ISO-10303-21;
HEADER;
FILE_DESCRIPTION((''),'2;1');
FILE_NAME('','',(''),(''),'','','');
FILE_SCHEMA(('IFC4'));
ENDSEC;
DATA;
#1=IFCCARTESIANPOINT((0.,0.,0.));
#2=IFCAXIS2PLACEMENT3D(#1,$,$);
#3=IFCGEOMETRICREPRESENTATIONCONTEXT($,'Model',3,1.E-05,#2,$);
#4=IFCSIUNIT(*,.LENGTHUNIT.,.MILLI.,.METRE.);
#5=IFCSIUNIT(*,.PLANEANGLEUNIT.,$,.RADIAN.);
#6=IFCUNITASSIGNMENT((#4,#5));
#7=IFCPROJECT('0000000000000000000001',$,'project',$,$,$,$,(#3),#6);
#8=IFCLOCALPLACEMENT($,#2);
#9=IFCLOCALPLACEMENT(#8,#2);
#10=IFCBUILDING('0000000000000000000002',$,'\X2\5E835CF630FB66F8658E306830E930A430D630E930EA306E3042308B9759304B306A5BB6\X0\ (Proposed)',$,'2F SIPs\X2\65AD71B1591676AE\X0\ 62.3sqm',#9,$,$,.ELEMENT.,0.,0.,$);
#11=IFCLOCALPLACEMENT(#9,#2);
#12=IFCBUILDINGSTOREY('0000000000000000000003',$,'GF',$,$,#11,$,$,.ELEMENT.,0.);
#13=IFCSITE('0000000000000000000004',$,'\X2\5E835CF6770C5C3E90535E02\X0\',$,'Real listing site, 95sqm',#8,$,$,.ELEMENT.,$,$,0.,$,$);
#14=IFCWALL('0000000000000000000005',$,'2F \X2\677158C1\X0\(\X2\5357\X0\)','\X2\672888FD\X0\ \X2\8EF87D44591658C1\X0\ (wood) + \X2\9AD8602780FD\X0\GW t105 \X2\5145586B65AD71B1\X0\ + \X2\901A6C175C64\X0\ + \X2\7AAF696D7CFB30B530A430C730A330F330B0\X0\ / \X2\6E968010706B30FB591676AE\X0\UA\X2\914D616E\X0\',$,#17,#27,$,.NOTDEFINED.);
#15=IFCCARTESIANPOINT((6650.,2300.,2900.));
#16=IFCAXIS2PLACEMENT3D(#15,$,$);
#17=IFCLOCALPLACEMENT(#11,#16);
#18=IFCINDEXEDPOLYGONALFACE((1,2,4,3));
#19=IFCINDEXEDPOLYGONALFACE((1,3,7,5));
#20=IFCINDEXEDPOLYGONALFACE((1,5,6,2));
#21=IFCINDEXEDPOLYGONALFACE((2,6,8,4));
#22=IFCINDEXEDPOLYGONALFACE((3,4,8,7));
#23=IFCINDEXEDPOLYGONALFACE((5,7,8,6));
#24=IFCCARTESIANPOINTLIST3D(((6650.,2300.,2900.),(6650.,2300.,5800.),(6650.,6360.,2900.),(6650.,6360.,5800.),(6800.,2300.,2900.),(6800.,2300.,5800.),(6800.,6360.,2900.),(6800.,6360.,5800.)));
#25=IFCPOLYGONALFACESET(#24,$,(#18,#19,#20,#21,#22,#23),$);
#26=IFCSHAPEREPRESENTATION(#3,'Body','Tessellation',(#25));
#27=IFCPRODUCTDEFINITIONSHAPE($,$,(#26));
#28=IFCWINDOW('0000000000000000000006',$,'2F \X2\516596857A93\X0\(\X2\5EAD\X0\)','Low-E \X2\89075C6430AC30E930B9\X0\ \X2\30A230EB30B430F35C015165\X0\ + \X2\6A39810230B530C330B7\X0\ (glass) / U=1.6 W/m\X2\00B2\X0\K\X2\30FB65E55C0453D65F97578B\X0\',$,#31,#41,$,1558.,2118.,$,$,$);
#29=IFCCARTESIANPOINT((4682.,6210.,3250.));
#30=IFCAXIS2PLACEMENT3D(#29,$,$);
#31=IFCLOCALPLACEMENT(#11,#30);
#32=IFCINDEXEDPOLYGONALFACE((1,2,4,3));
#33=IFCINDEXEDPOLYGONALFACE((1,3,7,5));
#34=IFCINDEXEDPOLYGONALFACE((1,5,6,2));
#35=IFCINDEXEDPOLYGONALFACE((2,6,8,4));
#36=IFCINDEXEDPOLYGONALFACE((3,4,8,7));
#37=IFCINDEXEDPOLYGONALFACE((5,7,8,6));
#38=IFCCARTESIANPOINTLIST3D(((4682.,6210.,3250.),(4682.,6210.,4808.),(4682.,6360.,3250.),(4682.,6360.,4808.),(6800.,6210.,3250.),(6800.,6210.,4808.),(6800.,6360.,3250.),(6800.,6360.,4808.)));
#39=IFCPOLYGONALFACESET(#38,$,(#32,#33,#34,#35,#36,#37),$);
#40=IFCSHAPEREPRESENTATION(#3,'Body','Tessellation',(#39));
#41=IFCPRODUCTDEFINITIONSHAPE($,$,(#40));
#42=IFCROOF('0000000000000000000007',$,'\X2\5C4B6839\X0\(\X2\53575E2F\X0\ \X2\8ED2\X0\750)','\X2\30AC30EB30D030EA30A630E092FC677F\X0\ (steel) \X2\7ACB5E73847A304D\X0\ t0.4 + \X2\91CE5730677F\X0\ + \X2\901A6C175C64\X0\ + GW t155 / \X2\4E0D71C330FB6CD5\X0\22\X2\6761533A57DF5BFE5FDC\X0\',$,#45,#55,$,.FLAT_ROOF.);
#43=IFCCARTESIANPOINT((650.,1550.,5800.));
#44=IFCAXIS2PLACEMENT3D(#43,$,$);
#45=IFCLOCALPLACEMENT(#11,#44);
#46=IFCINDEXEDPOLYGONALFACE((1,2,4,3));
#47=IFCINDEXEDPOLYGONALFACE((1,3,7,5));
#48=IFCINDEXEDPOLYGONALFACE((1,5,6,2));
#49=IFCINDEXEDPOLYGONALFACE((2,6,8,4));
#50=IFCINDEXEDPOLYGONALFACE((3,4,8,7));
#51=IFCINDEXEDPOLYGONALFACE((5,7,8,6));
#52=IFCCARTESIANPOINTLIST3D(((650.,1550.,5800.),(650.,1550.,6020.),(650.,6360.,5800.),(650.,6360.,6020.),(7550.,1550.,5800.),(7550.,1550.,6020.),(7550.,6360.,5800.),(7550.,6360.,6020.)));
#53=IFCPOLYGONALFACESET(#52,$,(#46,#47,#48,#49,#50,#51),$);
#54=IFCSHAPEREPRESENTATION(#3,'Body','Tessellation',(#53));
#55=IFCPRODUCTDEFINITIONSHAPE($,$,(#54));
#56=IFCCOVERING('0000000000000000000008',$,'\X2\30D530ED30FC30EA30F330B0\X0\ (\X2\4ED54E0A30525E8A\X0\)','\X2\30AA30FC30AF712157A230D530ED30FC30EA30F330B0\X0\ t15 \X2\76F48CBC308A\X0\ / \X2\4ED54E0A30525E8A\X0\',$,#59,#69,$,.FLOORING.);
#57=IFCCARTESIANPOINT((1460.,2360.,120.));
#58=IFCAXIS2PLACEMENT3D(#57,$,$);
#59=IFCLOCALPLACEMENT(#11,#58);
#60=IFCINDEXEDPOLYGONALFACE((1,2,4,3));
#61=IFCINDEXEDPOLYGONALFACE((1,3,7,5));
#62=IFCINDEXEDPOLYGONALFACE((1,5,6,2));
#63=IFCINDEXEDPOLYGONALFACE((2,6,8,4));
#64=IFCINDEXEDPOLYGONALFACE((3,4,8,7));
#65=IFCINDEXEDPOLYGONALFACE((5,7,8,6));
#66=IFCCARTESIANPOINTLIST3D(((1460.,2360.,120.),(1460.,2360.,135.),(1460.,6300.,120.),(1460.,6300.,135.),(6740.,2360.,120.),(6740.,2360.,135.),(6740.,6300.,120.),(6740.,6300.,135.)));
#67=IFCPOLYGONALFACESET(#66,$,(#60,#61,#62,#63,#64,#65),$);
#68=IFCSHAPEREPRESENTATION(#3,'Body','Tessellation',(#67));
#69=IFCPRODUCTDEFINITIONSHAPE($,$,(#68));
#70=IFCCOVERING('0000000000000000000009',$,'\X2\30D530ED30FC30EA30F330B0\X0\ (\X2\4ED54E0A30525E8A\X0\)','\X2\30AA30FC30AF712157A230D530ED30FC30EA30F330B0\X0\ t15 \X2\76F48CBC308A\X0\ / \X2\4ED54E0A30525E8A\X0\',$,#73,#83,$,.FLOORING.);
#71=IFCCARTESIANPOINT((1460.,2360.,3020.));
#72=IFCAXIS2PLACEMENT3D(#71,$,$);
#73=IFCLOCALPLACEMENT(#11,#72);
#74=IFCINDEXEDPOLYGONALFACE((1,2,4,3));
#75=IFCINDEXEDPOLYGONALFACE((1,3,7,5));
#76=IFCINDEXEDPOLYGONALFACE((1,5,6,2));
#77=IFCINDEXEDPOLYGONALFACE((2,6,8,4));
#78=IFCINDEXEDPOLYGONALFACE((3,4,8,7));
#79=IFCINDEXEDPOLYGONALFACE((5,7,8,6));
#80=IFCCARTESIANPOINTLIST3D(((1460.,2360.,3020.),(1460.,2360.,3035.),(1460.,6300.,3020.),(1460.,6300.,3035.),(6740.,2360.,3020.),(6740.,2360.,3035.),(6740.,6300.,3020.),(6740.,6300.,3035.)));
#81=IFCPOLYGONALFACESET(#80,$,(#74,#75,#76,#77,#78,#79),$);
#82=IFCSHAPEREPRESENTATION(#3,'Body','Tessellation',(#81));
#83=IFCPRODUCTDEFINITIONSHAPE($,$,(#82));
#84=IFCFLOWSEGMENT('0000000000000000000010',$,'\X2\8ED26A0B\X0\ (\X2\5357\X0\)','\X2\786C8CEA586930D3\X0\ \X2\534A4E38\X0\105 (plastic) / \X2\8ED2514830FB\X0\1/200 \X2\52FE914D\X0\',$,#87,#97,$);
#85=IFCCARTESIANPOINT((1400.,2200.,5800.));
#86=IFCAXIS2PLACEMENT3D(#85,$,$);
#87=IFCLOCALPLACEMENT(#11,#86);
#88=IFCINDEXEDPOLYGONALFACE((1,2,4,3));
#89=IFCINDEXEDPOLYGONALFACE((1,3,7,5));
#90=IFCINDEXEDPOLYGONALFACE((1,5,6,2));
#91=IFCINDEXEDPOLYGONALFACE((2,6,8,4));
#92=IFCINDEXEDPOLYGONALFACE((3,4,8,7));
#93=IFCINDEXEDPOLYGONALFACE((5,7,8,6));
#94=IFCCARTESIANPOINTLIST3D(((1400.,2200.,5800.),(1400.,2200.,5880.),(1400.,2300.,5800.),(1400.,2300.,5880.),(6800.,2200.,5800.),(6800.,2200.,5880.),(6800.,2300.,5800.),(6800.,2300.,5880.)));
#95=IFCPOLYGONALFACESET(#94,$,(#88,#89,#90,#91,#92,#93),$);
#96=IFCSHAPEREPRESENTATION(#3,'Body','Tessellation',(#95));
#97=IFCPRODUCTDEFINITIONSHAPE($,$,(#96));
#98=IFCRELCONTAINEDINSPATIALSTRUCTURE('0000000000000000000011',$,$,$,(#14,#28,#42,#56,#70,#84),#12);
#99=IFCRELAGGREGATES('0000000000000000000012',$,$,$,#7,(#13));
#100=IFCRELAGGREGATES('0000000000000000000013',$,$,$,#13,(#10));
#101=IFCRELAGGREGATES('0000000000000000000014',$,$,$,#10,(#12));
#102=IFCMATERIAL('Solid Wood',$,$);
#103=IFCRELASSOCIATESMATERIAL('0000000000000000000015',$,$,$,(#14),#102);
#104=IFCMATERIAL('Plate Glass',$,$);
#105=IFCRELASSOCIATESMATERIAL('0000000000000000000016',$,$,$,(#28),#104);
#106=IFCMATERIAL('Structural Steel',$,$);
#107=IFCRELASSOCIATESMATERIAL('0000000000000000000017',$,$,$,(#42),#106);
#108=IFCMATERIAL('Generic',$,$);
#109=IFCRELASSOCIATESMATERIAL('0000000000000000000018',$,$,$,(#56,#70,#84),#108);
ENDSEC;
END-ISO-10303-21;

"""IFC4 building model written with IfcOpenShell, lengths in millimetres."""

from ifc_helpers import new_model, si_unit, frame, frame_2d, origin, place, context, project, spatial, rectangle, extrude, material, element, fill, save


model = new_model("IFC4")

# Units and contexts
model_context = context("Model", 3, precision=1e-05, world=origin())
ifc_project = project(units=[si_unit("LENGTHUNIT", "METRE", prefix="MILLI"), si_unit("PLANEANGLEUNIT", "RADIAN")], contexts=[model_context])

# Site, building, storey
site_placement = place(None, origin())
site = spatial("IfcSite", under=ifc_project, at=site_placement, Name="広島県尾道市", ObjectType="Real listing site, 95sqm", CompositionType="ELEMENT", RefElevation=0.0)
building_placement = place(site_placement, origin())
building = spatial("IfcBuilding", under=site, at=building_placement, Name="広島・書斎とライブラリのある静かな家 (Proposed)", ObjectType="2F SIPs断熱外皮 62.3sqm", CompositionType="ELEMENT", ElevationOfRefHeight=0.0, ElevationOfTerrain=0.0)
storey_placement = place(building_placement, origin())
storey = spatial("IfcBuildingStorey", under=building, at=storey_placement, Name="GF", CompositionType="ELEMENT", Elevation=0.0)

# Shared definitions
ifc_material_1 = material(Name="Solid Wood")

# Wall, opening, window
ifc_material_2 = material(Name="Plate Glass")
wall_1_placement = place(storey_placement, frame((6650.0, 2300.0, 2900.0)))
wall_1 = element("IfcWall", 1, at=wall_1_placement, inside=storey, material=ifc_material_1, Name="2F 東壁(南)", Description="木製 軸組外壁 (wood) + 高性能GW t105 充填断熱 + 通気層 + 窯業系サイディング / 準耐火・外皮UA配慮", PredefinedType="NOTDEFINED", context=model_context, shape_type="SweptSolid", body=[
    extrude(rectangle(XDim=150.0, YDim=4060.0, at=frame_2d((75.0, 2030.0))), frame((6650.0, 2300.0, 2900.0)), (0.0, 0.0, 1.0), 2900.0),
])
opening_1_placement = place(storey_placement, frame((4682.0, 6210.0, 3250.0)))
opening_1 = element("IfcOpeningElement", 2, at=opening_1_placement, cuts=wall_1, PredefinedType="NOTDEFINED", context=model_context, shape_type="SweptSolid", body=[
    extrude(rectangle(XDim=2118.0, YDim=150.0, at=frame_2d((1059.0, 75.0))), frame((4682.0, 6210.0, 3250.0)), (0.0, 0.0, 1.0), 1558.0),
])
window_1_placement = place(storey_placement, frame((4682.0, 6210.0, 3250.0)))
window_1 = element("IfcWindow", 3, at=window_1_placement, inside=storey, material=ifc_material_2, Name="2F 入隅窓(庭)", Description="Low-E 複層ガラス アルゴン封入 + 樹脂サッシ (glass) / U=1.6 W/m²K・日射取得型", OverallHeight=1558.0, OverallWidth=2118.0, context=model_context, shape_type="SweptSolid", body=[
    extrude(rectangle(XDim=2118.0, YDim=150.0, at=frame_2d((1059.0, 75.0))), frame((4682.0, 6210.0, 3250.0)), (0.0, 0.0, 1.0), 1558.0),
])
fill(opening_1, window_1)

# Roof
ifc_material_3 = material(Name="Structural Steel")
for number, where, name in (
    (4, (650.0, 1550.0, 5800.0), "屋根(南帯 軒750)"),
):
    element("IfcRoof", number, at=place(storey_placement, frame(where)), inside=storey, material=ifc_material_3, Name=name, Description="ガルバリウム鋼板 (steel) 立平葺き t0.4 + 野地板 + 通気層 + GW t155 / 不燃・法22条区域対応", PredefinedType="FLAT_ROOF", context=model_context, shape_type="SweptSolid", body=[
        extrude(rectangle(XDim=6900.0, YDim=4810.0, at=frame_2d((3450.0, 2405.0))), frame((650.0, 1550.0, 5800.0)), (0.0, 0.0, 1.0), 220.0),
    ])

# Coverings
ifc_material_4 = material(Name="Generic")
covering_1_placement = place(storey_placement, frame((1460.0, 2360.0, 120.0)))
element("IfcCovering", 5, at=covering_1_placement, inside=storey, material=ifc_material_4, Name="フローリング (仕上げ床)", Description="オーク無垢フローリング t15 直貼り / 仕上げ床", PredefinedType="FLOORING", context=model_context, shape_type="SweptSolid", body=[
    extrude(rectangle(XDim=5280.0, YDim=3940.0, at=frame_2d((2640.0, 1970.0))), frame((1460.0, 2360.0, 120.0)), (0.0, 0.0, 1.0), 15.0),
])
covering_2_placement = place(storey_placement, frame((1460.0, 2360.0, 3020.0)))
element("IfcCovering", 6, at=covering_2_placement, inside=storey, material=ifc_material_4, Name="フローリング (仕上げ床)", Description="オーク無垢フローリング t15 直貼り / 仕上げ床", PredefinedType="FLOORING", context=model_context, shape_type="SweptSolid", body=[
    extrude(rectangle(XDim=5280.0, YDim=3940.0, at=frame_2d((2640.0, 1970.0))), frame((1460.0, 2360.0, 3020.0)), (0.0, 0.0, 1.0), 15.0),
])

# Flow segment
flow_segment_placement = place(storey_placement, frame((1400.0, 2200.0, 5800.0)))
element("IfcFlowSegment", 7, at=flow_segment_placement, inside=storey, material=ifc_material_4, Name="軒樋 (南)", Description="硬質塩ビ 半丸105 (plastic) / 軒先・1/200 勾配", context=model_context, shape_type="SweptSolid", body=[
    extrude(rectangle(XDim=5400.0, YDim=100.0, at=frame_2d((2700.0, 50.0))), frame((1400.0, 2200.0, 5800.0)), (0.0, 0.0, 1.0), 80.0),
])

save(model, "model.ifc")
